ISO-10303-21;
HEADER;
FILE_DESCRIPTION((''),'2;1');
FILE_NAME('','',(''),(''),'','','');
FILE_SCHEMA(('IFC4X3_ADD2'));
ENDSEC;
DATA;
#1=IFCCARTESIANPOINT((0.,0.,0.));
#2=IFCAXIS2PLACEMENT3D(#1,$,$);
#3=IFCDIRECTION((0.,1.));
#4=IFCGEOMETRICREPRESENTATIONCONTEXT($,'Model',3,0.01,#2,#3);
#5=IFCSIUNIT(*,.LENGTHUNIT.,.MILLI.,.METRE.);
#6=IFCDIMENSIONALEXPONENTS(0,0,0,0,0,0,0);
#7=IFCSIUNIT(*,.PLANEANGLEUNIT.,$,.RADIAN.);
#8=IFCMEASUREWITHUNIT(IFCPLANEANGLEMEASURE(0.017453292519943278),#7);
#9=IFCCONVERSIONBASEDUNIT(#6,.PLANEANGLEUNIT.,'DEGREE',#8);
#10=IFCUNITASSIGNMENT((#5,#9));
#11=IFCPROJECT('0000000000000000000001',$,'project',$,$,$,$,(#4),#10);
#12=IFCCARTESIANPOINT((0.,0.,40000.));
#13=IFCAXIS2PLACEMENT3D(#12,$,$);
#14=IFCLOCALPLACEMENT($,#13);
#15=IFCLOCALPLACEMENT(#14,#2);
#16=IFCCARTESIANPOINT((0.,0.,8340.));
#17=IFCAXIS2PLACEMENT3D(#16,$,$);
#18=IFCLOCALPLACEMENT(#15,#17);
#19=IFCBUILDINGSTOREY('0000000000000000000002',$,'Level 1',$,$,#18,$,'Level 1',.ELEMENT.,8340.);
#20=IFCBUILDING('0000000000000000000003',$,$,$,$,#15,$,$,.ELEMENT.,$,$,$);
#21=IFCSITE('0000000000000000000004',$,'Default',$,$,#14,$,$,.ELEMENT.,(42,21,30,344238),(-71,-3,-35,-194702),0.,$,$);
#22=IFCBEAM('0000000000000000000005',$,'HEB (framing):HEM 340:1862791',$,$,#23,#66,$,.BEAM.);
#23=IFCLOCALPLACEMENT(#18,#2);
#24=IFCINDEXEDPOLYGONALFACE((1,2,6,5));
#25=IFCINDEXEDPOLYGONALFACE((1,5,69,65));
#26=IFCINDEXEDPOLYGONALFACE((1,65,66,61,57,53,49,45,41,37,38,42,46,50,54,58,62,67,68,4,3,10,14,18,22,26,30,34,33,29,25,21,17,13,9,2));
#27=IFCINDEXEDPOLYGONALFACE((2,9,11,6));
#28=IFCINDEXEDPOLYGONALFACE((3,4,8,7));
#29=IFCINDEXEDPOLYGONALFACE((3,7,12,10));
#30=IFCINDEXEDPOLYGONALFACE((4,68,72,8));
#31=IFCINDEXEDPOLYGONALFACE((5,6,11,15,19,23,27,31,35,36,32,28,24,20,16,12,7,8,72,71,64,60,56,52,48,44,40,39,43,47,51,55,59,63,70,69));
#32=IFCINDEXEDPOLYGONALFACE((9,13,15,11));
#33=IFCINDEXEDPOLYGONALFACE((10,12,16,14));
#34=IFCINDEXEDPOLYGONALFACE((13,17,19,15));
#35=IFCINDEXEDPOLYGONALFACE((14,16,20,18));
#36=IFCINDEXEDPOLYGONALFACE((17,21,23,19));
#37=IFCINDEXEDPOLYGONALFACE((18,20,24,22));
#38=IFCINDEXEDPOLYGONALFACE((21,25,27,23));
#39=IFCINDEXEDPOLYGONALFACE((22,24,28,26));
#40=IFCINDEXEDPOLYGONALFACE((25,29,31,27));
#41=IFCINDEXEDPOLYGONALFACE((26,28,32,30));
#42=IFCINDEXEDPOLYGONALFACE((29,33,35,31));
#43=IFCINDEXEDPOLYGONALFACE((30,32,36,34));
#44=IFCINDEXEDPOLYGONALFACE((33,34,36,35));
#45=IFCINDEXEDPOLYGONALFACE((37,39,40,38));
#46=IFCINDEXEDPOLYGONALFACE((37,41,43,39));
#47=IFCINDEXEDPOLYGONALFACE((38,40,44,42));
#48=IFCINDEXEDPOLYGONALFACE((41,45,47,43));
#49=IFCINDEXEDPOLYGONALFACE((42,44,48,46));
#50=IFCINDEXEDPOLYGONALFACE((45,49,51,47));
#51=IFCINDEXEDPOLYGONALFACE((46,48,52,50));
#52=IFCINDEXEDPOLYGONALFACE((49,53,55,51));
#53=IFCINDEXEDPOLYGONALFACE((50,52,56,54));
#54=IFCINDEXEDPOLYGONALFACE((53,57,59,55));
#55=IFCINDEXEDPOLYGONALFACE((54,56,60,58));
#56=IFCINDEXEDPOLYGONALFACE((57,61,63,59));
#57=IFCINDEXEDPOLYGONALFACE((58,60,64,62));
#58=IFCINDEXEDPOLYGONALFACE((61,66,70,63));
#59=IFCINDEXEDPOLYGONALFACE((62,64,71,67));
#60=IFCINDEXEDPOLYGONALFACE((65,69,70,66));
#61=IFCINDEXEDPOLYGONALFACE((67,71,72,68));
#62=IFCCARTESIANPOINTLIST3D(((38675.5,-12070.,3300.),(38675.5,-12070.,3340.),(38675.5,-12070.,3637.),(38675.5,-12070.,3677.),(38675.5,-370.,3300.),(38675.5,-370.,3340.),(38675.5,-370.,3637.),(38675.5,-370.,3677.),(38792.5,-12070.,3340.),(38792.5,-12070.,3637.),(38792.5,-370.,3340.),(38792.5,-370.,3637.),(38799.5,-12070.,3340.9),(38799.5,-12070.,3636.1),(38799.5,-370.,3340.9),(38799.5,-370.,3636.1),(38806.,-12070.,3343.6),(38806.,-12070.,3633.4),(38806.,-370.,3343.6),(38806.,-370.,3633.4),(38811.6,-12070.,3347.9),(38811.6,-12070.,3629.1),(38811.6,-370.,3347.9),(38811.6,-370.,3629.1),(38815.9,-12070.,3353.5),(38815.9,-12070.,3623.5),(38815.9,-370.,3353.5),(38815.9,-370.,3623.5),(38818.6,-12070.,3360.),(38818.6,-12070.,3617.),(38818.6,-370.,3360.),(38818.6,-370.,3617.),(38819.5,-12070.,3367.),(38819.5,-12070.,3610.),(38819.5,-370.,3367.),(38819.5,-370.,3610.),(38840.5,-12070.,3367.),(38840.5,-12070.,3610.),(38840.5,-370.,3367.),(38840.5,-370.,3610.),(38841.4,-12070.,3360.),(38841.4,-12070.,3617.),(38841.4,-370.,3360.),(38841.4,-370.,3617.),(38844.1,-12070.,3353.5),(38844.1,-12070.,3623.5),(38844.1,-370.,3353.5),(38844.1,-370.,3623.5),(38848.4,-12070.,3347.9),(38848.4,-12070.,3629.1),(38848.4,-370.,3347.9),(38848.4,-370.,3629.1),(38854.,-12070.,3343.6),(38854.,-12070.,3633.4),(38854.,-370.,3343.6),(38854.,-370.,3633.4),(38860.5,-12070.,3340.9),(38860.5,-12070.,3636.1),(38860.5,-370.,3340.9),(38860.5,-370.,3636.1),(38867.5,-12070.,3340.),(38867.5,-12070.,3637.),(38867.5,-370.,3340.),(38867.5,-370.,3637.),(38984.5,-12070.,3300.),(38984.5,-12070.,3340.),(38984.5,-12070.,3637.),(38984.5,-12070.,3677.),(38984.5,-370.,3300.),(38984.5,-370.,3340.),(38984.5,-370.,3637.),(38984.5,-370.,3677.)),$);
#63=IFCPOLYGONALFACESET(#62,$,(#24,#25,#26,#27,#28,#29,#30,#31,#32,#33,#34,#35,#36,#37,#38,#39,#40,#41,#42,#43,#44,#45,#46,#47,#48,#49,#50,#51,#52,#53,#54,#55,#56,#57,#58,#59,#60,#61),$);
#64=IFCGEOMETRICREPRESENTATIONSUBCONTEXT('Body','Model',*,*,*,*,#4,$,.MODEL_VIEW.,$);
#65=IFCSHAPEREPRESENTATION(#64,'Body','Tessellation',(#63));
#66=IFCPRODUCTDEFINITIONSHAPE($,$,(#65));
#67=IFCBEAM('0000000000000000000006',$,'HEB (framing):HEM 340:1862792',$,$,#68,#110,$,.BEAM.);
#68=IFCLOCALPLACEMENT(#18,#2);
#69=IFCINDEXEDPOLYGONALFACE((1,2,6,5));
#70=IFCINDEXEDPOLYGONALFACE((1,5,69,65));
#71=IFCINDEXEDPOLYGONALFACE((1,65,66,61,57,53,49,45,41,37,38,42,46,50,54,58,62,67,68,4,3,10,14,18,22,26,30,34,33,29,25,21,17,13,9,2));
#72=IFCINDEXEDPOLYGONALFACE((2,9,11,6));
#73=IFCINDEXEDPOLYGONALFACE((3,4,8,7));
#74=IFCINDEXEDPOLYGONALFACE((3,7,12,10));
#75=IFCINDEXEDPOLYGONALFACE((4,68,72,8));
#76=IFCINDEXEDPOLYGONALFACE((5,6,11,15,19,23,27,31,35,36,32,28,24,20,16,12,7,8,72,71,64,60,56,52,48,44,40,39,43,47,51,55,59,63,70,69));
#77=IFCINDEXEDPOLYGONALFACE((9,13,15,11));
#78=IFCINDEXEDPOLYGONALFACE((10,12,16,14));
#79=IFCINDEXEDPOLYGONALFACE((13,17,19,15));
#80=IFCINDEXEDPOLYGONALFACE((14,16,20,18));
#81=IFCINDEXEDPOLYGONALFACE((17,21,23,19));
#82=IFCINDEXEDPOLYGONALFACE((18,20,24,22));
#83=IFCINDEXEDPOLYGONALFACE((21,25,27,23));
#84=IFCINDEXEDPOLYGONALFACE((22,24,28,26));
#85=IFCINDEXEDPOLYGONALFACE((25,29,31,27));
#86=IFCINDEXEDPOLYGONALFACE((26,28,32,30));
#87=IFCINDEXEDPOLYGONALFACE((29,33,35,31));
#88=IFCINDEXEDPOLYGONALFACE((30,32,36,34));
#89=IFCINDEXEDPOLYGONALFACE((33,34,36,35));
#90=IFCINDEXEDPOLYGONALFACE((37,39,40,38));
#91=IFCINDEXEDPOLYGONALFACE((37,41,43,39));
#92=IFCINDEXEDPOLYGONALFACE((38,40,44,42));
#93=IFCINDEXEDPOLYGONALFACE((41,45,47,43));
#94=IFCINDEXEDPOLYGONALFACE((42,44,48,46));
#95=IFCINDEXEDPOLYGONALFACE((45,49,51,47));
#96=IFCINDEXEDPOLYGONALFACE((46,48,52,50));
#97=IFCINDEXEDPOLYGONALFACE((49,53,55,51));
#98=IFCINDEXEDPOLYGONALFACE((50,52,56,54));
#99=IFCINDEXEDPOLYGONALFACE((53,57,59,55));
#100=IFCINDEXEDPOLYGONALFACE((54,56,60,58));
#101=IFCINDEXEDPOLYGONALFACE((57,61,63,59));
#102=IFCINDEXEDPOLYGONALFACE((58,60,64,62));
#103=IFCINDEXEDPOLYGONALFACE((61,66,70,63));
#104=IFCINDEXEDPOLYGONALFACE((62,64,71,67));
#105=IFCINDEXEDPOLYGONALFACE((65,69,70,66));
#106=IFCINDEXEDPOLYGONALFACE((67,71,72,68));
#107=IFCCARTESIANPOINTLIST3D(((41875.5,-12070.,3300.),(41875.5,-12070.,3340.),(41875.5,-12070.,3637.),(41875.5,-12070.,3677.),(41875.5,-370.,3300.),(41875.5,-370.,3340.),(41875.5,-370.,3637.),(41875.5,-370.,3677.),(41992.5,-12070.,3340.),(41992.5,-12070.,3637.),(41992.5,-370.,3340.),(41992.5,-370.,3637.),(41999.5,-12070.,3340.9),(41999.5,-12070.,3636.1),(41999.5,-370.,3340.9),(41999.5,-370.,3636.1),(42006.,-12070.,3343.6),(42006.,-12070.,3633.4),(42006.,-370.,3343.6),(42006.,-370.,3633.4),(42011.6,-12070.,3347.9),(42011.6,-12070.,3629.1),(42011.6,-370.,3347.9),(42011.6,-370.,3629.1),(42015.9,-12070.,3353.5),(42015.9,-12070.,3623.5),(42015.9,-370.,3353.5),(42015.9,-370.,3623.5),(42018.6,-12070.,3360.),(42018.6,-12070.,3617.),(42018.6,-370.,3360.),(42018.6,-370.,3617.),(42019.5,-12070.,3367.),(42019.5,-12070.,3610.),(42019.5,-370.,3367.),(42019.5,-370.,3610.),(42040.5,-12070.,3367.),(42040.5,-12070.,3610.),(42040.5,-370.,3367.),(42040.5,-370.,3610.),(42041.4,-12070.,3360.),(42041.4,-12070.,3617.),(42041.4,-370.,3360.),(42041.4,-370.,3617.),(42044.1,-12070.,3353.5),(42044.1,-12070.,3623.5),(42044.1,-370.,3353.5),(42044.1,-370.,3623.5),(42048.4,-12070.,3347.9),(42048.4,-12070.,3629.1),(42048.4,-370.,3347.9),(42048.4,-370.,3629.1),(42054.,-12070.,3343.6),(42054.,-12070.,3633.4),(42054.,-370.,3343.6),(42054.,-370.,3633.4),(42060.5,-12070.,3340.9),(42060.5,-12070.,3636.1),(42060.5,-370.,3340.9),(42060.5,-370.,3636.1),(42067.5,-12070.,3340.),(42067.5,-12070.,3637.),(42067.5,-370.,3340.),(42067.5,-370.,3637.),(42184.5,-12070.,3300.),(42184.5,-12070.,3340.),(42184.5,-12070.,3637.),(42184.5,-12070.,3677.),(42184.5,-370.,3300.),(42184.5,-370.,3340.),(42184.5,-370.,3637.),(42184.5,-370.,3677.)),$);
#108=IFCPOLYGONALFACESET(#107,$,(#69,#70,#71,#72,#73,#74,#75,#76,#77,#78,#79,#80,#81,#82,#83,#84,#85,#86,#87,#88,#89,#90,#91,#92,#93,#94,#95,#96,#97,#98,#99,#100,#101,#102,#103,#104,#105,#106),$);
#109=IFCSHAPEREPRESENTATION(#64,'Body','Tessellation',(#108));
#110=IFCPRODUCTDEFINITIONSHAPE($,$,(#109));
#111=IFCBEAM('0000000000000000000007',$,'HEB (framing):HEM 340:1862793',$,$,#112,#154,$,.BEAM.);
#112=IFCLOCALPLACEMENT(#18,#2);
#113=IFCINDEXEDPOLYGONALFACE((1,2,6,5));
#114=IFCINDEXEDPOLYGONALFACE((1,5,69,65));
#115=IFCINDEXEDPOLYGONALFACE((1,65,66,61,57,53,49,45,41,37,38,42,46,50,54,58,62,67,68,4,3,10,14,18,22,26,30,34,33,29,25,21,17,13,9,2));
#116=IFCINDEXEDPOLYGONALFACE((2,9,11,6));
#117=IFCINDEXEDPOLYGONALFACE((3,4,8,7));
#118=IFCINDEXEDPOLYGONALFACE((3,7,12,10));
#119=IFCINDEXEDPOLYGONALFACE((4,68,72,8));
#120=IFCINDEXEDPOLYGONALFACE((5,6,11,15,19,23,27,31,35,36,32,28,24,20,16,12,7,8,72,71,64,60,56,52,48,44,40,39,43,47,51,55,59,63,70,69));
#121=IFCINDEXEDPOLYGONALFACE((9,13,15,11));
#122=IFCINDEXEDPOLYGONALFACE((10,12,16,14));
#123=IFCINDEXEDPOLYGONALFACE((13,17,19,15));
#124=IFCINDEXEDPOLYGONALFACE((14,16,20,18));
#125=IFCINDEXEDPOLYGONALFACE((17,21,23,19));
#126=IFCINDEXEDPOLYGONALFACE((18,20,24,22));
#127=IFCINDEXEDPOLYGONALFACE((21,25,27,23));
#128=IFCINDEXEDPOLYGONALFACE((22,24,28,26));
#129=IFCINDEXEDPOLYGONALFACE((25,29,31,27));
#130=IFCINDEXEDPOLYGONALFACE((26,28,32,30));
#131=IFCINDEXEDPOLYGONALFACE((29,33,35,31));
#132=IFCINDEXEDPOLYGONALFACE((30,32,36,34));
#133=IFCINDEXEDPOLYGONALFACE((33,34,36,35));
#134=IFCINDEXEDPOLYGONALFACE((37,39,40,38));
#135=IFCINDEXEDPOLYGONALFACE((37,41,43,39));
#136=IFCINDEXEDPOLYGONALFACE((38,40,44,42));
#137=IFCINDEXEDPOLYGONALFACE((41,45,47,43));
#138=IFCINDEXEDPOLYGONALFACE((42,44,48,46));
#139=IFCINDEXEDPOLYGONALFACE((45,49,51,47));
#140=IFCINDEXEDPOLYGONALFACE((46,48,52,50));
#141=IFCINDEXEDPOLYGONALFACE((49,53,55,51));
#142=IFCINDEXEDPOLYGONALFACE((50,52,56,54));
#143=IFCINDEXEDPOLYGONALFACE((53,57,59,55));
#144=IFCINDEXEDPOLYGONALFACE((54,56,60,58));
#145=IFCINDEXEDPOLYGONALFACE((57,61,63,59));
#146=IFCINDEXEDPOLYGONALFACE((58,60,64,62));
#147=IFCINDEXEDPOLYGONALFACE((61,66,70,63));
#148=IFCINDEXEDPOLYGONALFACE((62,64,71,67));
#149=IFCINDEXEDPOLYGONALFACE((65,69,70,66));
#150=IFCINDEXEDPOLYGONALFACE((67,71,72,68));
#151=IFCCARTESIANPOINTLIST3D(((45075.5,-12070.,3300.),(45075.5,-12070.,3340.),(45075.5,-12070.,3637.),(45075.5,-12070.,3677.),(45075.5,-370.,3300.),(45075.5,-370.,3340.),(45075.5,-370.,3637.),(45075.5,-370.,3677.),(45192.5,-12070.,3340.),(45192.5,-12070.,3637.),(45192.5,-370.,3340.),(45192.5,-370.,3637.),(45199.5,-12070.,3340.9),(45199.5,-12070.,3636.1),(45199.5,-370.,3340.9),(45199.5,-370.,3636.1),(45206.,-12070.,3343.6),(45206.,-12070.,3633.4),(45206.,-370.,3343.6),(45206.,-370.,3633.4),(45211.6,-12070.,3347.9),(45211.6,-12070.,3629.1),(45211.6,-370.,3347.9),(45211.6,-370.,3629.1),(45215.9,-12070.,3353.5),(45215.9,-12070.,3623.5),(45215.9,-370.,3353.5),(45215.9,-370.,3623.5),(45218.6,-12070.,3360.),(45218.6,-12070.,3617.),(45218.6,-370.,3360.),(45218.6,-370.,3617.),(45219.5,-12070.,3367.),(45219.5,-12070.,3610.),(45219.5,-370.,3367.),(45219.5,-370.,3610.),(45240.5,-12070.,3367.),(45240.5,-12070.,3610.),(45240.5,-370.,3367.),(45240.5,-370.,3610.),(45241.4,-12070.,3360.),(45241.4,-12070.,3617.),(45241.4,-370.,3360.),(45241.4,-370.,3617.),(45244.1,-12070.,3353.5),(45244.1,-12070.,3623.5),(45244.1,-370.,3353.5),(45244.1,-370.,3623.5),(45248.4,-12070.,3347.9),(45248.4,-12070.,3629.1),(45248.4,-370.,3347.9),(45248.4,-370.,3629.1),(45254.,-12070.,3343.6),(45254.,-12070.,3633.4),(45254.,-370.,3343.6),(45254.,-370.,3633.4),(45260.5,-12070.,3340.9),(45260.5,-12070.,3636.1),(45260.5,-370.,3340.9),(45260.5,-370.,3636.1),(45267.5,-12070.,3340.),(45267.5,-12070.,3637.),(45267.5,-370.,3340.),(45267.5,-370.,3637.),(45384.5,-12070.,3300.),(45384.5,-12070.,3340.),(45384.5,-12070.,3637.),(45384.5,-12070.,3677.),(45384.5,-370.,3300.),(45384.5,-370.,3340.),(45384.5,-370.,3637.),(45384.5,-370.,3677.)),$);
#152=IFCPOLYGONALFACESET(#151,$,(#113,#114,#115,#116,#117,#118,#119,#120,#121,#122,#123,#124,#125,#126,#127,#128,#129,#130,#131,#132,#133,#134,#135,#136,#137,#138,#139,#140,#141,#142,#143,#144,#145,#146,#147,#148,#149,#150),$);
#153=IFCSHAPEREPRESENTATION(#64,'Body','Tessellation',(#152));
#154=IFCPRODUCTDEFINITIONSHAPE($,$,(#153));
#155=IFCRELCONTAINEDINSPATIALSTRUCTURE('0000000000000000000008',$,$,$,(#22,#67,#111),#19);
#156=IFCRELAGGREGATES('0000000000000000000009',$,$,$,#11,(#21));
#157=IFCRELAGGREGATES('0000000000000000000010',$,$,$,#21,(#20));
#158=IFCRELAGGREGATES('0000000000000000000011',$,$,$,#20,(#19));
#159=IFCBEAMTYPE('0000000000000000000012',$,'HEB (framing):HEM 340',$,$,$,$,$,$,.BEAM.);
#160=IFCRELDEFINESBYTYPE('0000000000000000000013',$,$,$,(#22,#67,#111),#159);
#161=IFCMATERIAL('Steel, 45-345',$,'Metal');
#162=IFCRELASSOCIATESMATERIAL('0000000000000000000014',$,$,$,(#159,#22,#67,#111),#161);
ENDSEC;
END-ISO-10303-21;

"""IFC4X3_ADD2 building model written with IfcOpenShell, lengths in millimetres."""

from ifc_helpers import new_model, entity, si_unit, converted_unit, direction, frame, frame_2d, origin, place, context, subcontext, project, spatial, polyline, circle_curve, parameter, trimmed, segment, composite_curve, outline, extrude, source, transform, mapped, material, material_profile, profile_set, profile_usage, type_object, type_shapes, element, save


model = new_model("IFC4X3_ADD2")

# Units and contexts
model_context = context("Model", 3, precision=0.01, world=origin(), true_north=direction((0.0, 1.0)))
body_context = subcontext(model_context, "Body", "Model", "MODEL_VIEW")
ifc_project = project(units=[si_unit("LENGTHUNIT", "METRE", prefix="MILLI"), converted_unit("PLANEANGLEUNIT", "DEGREE", entity("IfcPlaneAngleMeasure", 0.017453292519943278), si_unit("PLANEANGLEUNIT", "RADIAN"), dimensions=[0, 0, 0, 0, 0, 0, 0])], contexts=[model_context])

# Site, building, storey
site_placement = place(None, frame((0.0, 0.0, 40000.0)))
site = spatial("IfcSite", under=ifc_project, at=site_placement, Name="Default", CompositionType="ELEMENT", RefLatitude=(42, 21, 30, 344238), RefLongitude=(-71, -3, -35, -194702), RefElevation=0.0)
building_placement = place(site_placement, origin())
building = spatial("IfcBuilding", under=site, at=building_placement, CompositionType="ELEMENT")
storey_placement = place(building_placement, frame((0.0, 0.0, 8340.0)))
storey = spatial("IfcBuildingStorey", under=building, at=storey_placement, Name="Level 1", LongName="Level 1", CompositionType="ELEMENT", Elevation=8340.0)

# Shared definitions
ifc_material = material(Name="Steel, 45-345", Category="Metal")

# Beams
ifc_material_profile_1 = material_profile(ifc_material, outline(composite_curve([segment(polyline([(-154.5, -148.5), (-154.5, -188.5)]), True, "CONTINUOUS"), segment(polyline([(-154.5, -188.5), (154.5, -188.5)]), True, "CONTINUOUS"), segment(polyline([(154.5, -188.5), (154.5, -148.5)]), True, "CONTINUOUS"), segment(polyline([(154.5, -148.5), (37.5, -148.5)]), True, "CONTINUOUS"), segment(trimmed(circle_curve(frame_2d((37.5, -121.5), x_axis=(1.0, 0.0)), 27.0), [parameter(180.0)], [parameter(270.0)], True, "PARAMETER"), False, "CONTINUOUS"), segment(polyline([(10.5, -121.5), (10.5, 121.5)]), True, "CONTINUOUS"), segment(trimmed(circle_curve(frame_2d((37.5, 121.5), x_axis=(1.0, 0.0)), 27.0), [parameter(90.0)], [parameter(180.0)], True, "PARAMETER"), False, "CONTINUOUS"), segment(polyline([(37.5, 148.5), (154.5, 148.5)]), True, "CONTINUOUS"), segment(polyline([(154.5, 148.5), (154.5, 188.5)]), True, "CONTINUOUS"), segment(polyline([(154.5, 188.5), (-154.5, 188.5)]), True, "CONTINUOUS"), segment(polyline([(-154.5, 188.5), (-154.5, 148.5)]), True, "CONTINUOUS"), segment(polyline([(-154.5, 148.5), (-37.5, 148.5)]), True, "CONTINUOUS"), segment(trimmed(circle_curve(frame_2d((-37.5, 121.5), x_axis=(1.0, 0.0)), 27.0), [parameter(360.0)], [parameter(90.0)], True, "PARAMETER"), False, "CONTINUOUS"), segment(polyline([(-10.5, 121.5), (-10.5, -121.5)]), True, "CONTINUOUS"), segment(trimmed(circle_curve(frame_2d((-37.5, -121.5), x_axis=(1.0, 0.0)), 27.0), [parameter(270.0)], [parameter(0.0)], True, "PARAMETER"), False, "CONTINUOUS"), segment(polyline([(-37.5, -148.5), (-154.5, -148.5)]), True, "CONTINUOUS")], self_intersect=False)), Name="HEM 340")
ifc_profile_set_1 = profile_set([ifc_material_profile_1], Name="HEM 340")
ifc_profile_usage_1 = profile_usage(ifc_profile_set_1, cardinal=8)
beam_type_1 = type_object("IfcBeamType", Name="HEB (framing):HEM 340", PredefinedType="BEAM", material=ifc_profile_set_1)
shared_shape_1 = source(origin(), body_context, "Body", "SweptSolid", [
    extrude(outline(composite_curve([segment(polyline([(-154.5, -148.5), (-154.5, -188.5)]), True, "CONTINUOUS"), segment(polyline([(-154.5, -188.5), (154.5, -188.5)]), True, "CONTINUOUS"), segment(polyline([(154.5, -188.5), (154.5, -148.5)]), True, "CONTINUOUS"), segment(polyline([(154.5, -148.5), (37.5, -148.5)]), True, "CONTINUOUS"), segment(trimmed(circle_curve(frame_2d((37.5, -121.5), x_axis=(1.0, 0.0)), 27.0), [parameter(180.0)], [parameter(270.0)], True, "PARAMETER"), False, "CONTINUOUS"), segment(polyline([(10.5, -121.5), (10.5, 121.5)]), True, "CONTINUOUS"), segment(trimmed(circle_curve(frame_2d((37.5, 121.5), x_axis=(1.0, 0.0)), 27.0), [parameter(90.0)], [parameter(180.0)], True, "PARAMETER"), False, "CONTINUOUS"), segment(polyline([(37.5, 148.5), (154.5, 148.5)]), True, "CONTINUOUS"), segment(polyline([(154.5, 148.5), (154.5, 188.5)]), True, "CONTINUOUS"), segment(polyline([(154.5, 188.5), (-154.5, 188.5)]), True, "CONTINUOUS"), segment(polyline([(-154.5, 188.5), (-154.5, 148.5)]), True, "CONTINUOUS"), segment(polyline([(-154.5, 148.5), (-37.5, 148.5)]), True, "CONTINUOUS"), segment(trimmed(circle_curve(frame_2d((-37.5, 121.5), x_axis=(1.0, 0.0)), 27.0), [parameter(360.0)], [parameter(90.0)], True, "PARAMETER"), False, "CONTINUOUS"), segment(polyline([(-10.5, 121.5), (-10.5, -121.5)]), True, "CONTINUOUS"), segment(trimmed(circle_curve(frame_2d((-37.5, -121.5), x_axis=(1.0, 0.0)), 27.0), [parameter(270.0)], [parameter(0.0)], True, "PARAMETER"), False, "CONTINUOUS"), segment(polyline([(-37.5, -148.5), (-154.5, -148.5)]), True, "CONTINUOUS")], self_intersect=False)), frame((-5850.0, 0.0, 0.0), z_axis=(-1.0, 0.0, 0.0), x_axis=(0.0, -1.0, 0.0)), (0.0, 0.0, -1.0), 11700.0),
])
type_shapes(beam_type_1, [shared_shape_1])
for number, where, z_axis, x_axis, name in (
    (1, (38830.0, -6220.0, 3488.5), (0.0, 0.0, 1.0), (0.0, -1.0, 0.0), "HEB (framing):HEM 340:1862791"),
    (2, (42030.0, -6220.0, 3488.5), (0.0, 0.0, 1.0), (0.0, -1.0, 0.0), "HEB (framing):HEM 340:1862792"),
    (3, (45230.0, -6220.0, 3488.5), (0.0, 0.0, 1.0), (0.0, -1.0, 0.0), "HEB (framing):HEM 340:1862793"),
):
    element("IfcBeam", number, at=place(storey_placement, frame(where, z_axis=z_axis, x_axis=x_axis)), inside=storey, type_object=beam_type_1, material=ifc_profile_usage_1, Name=name, PredefinedType="BEAM", context=body_context, shape_type="MappedRepresentation", body=[
        mapped(shared_shape_1, transform((0.0, 0.0, 0.0), scale=1.0)),
    ])

save(model, "model.ifc")
